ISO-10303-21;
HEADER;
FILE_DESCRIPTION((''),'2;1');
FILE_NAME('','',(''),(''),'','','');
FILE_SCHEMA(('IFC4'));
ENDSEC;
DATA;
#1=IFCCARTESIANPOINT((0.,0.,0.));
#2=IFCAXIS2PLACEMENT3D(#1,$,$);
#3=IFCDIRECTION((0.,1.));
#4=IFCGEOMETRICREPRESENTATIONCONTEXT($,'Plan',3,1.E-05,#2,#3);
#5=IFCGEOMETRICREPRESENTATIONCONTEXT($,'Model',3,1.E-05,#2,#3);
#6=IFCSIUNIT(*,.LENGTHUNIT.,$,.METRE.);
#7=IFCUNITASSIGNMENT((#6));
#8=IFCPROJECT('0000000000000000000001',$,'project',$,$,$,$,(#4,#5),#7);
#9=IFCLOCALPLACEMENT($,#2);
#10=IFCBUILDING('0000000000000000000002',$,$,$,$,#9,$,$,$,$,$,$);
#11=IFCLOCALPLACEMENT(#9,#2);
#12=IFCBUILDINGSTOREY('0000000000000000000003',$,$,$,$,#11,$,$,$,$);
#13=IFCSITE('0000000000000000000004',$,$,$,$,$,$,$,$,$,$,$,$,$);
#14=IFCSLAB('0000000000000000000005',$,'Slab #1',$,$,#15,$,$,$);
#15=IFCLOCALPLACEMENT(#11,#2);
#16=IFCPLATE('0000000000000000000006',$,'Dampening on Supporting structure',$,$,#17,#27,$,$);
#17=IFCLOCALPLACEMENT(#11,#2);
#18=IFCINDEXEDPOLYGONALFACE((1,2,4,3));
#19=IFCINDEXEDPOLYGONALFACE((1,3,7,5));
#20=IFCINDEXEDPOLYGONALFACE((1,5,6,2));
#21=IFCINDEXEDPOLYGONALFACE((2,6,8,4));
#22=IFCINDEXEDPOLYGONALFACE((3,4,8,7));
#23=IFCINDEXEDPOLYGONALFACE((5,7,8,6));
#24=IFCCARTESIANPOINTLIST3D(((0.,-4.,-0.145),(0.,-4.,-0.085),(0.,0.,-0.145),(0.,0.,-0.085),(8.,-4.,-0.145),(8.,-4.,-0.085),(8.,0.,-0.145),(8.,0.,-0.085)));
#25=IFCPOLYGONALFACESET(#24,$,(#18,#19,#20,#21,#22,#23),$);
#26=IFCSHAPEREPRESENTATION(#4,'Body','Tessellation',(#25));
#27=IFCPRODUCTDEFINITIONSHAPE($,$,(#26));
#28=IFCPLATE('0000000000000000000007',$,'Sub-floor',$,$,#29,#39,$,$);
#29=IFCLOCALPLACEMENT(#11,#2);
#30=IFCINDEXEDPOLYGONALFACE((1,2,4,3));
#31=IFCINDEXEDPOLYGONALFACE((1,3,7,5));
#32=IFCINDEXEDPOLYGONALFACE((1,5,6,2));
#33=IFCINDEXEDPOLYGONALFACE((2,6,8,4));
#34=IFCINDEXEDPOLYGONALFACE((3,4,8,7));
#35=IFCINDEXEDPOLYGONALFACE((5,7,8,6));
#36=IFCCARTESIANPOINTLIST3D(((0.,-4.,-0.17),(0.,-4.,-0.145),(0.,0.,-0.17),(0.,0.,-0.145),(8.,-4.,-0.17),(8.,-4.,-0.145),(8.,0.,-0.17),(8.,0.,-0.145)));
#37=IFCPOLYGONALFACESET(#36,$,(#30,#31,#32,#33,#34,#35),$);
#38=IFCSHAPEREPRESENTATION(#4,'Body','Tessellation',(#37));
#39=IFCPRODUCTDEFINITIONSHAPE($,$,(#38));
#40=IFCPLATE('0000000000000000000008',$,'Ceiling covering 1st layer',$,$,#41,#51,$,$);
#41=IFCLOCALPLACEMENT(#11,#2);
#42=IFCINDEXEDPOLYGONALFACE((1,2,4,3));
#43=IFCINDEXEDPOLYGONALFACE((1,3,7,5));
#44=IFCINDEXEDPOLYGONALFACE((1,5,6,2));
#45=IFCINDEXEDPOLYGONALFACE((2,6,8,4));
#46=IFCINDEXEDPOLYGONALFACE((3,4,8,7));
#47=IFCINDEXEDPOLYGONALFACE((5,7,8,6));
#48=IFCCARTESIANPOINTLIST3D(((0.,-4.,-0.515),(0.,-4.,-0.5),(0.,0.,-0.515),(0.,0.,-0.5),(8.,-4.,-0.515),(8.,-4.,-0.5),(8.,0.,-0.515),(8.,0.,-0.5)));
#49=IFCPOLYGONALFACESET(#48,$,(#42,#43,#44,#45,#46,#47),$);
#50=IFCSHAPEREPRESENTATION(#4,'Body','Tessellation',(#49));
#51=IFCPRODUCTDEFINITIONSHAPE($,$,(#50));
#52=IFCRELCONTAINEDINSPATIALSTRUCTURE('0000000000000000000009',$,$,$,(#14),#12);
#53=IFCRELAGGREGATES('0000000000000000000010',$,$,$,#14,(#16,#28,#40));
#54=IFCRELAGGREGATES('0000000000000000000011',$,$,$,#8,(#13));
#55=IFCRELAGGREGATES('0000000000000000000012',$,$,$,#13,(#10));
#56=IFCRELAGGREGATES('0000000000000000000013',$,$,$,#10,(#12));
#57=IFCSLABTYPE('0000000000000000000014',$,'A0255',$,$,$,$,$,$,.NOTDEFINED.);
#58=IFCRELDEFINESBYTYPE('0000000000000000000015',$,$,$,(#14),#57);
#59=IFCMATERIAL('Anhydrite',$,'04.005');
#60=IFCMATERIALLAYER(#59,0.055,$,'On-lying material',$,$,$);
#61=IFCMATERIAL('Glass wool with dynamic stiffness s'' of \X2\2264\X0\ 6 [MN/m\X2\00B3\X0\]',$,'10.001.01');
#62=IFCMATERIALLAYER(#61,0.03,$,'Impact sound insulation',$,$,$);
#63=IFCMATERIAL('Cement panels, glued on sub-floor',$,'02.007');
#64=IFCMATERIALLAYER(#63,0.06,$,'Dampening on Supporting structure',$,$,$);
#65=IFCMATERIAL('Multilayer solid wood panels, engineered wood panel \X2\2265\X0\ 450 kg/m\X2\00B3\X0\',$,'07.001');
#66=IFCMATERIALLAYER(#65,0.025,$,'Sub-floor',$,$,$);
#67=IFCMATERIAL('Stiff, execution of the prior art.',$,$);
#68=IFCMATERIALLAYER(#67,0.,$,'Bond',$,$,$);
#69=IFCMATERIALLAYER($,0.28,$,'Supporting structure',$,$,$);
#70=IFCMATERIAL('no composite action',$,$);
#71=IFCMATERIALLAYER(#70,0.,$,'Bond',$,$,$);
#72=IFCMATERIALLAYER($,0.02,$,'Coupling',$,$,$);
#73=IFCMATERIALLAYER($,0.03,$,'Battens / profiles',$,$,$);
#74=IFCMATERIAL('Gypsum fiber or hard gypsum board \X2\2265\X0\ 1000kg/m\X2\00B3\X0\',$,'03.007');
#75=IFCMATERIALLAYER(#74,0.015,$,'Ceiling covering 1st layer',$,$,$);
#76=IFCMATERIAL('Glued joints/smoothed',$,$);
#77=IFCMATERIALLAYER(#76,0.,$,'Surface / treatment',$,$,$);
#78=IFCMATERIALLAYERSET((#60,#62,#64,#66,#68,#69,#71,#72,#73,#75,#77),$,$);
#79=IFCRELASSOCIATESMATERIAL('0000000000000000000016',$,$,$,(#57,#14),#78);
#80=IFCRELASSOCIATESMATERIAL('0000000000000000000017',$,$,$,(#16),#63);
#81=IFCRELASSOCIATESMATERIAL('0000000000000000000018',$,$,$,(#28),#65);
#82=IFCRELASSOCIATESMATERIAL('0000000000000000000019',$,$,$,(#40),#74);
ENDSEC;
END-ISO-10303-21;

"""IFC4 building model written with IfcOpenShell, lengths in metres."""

from ifc_helpers import new_model, si_unit, direction, frame, frame_2d, origin, place, context, project, spatial, rectangle, extrude, material, layer, layer_set, type_object, element, aggregate, save


model = new_model("IFC4")

# Units and contexts
plan_context = context("Plan", 3, precision=1e-05, world=origin(), true_north=direction((0.0, 1.0)))
model_context = context("Model", 3, precision=1e-05, world=origin(), true_north=direction((0.0, 1.0)))
ifc_project = project(units=[si_unit("LENGTHUNIT", "METRE")], contexts=[plan_context, model_context])

# Site, building, storey
site = spatial("IfcSite", under=ifc_project)
building_placement = place(None, origin())
building = spatial("IfcBuilding", under=site, at=building_placement)
storey_placement = place(building_placement, origin())
storey = spatial("IfcBuildingStorey", under=building, at=storey_placement)

# Slab, plates
ifc_material_1 = material(Name="Anhydrite", Category="04.005")
ifc_layer_1 = layer(ifc_material_1, 0.055, Name="On-lying material")
ifc_material_2 = material(Name="Glass wool with dynamic stiffness s' of ≤ 6 [MN/m³]", Category="10.001.01")
ifc_layer_2 = layer(ifc_material_2, 0.03, Name="Impact sound insulation")
ifc_material_3 = material(Name="Cement panels, glued on sub-floor", Category="02.007")
ifc_layer_3 = layer(ifc_material_3, 0.06, Name="Dampening on Supporting structure")
ifc_material_4 = material(Name="Multilayer solid wood panels, engineered wood panel ≥ 450 kg/m³", Category="07.001")
ifc_layer_4 = layer(ifc_material_4, 0.025, Name="Sub-floor")
ifc_material_5 = material(Name="Stiff, execution of the prior art.")
ifc_layer_5 = layer(ifc_material_5, 0.0, Name="Bond")
ifc_layer_6 = layer(None, 0.28, Name="Supporting structure")
ifc_material_6 = material(Name="no composite action")
ifc_layer_7 = layer(ifc_material_6, 0.0, Name="Bond")
ifc_layer_8 = layer(None, 0.02, Name="Coupling")
ifc_layer_9 = layer(None, 0.03, Name="Battens / profiles")
ifc_material_7 = material(Name="Gypsum fiber or hard gypsum board ≥ 1000kg/m³", Category="03.007")
ifc_layer_10 = layer(ifc_material_7, 0.015, Name="Ceiling covering 1st layer")
ifc_material_8 = material(Name="Glued joints/smoothed")
ifc_layer_11 = layer(ifc_material_8, 0.0, Name="Surface / treatment")
ifc_layer_set = layer_set([ifc_layer_1, ifc_layer_2, ifc_layer_3, ifc_layer_4, ifc_layer_5, ifc_layer_6, ifc_layer_7, ifc_layer_8, ifc_layer_9, ifc_layer_10, ifc_layer_11])
slab_type = type_object("IfcSlabType", Name="A0255", PredefinedType="NOTDEFINED", material=ifc_layer_set)
slab_placement = place(None, frame((0.0, 0.0, 0.0), z_axis=(0.0, 0.0, -1.0), x_axis=(1.0, 0.0, 0.0)))
slab = element("IfcSlab", 1, at=slab_placement, inside=storey, type_object=slab_type, material=ifc_layer_set, Name="Slab #1")
plate_1_placement = place(slab_placement, origin())
plate_1 = element("IfcPlate", 2, at=plate_1_placement, material=ifc_material_3, Name="Dampening on Supporting structure", context=plan_context, shape_type="SweptSolid", body=[
    extrude(rectangle(XDim=8.0, YDim=4.0, at=frame_2d((4.0, 2.0), x_axis=(1.0, 0.0))), frame((0.0, 0.0, 0.085), z_axis=(0.0, 0.0, 1.0), x_axis=(1.0, 0.0, 0.0)), (0.0, 0.0, 1.0), 0.06),
])
plate_2_placement = place(slab_placement, origin())
plate_2 = element("IfcPlate", 3, at=plate_2_placement, material=ifc_material_4, Name="Sub-floor", context=plan_context, shape_type="SweptSolid", body=[
    extrude(rectangle(XDim=8.0, YDim=4.0, at=frame_2d((4.0, 2.0), x_axis=(1.0, 0.0))), frame((0.0, 0.0, 0.145), z_axis=(0.0, 0.0, 1.0), x_axis=(1.0, 0.0, 0.0)), (0.0, 0.0, 1.0), 0.025),
])
plate_3_placement = place(slab_placement, origin())
plate_3 = element("IfcPlate", 4, at=plate_3_placement, material=ifc_material_7, Name="Ceiling covering 1st layer", context=plan_context, shape_type="SweptSolid", body=[
    extrude(rectangle(XDim=8.0, YDim=4.0, at=frame_2d((4.0, 2.0), x_axis=(1.0, 0.0))), frame((0.0, 0.0, 0.5), z_axis=(0.0, 0.0, 1.0), x_axis=(1.0, 0.0, 0.0)), (0.0, 0.0, 1.0), 0.015),
])
aggregate(slab, [plate_1, plate_2, plate_3])

save(model, "model.ifc")
